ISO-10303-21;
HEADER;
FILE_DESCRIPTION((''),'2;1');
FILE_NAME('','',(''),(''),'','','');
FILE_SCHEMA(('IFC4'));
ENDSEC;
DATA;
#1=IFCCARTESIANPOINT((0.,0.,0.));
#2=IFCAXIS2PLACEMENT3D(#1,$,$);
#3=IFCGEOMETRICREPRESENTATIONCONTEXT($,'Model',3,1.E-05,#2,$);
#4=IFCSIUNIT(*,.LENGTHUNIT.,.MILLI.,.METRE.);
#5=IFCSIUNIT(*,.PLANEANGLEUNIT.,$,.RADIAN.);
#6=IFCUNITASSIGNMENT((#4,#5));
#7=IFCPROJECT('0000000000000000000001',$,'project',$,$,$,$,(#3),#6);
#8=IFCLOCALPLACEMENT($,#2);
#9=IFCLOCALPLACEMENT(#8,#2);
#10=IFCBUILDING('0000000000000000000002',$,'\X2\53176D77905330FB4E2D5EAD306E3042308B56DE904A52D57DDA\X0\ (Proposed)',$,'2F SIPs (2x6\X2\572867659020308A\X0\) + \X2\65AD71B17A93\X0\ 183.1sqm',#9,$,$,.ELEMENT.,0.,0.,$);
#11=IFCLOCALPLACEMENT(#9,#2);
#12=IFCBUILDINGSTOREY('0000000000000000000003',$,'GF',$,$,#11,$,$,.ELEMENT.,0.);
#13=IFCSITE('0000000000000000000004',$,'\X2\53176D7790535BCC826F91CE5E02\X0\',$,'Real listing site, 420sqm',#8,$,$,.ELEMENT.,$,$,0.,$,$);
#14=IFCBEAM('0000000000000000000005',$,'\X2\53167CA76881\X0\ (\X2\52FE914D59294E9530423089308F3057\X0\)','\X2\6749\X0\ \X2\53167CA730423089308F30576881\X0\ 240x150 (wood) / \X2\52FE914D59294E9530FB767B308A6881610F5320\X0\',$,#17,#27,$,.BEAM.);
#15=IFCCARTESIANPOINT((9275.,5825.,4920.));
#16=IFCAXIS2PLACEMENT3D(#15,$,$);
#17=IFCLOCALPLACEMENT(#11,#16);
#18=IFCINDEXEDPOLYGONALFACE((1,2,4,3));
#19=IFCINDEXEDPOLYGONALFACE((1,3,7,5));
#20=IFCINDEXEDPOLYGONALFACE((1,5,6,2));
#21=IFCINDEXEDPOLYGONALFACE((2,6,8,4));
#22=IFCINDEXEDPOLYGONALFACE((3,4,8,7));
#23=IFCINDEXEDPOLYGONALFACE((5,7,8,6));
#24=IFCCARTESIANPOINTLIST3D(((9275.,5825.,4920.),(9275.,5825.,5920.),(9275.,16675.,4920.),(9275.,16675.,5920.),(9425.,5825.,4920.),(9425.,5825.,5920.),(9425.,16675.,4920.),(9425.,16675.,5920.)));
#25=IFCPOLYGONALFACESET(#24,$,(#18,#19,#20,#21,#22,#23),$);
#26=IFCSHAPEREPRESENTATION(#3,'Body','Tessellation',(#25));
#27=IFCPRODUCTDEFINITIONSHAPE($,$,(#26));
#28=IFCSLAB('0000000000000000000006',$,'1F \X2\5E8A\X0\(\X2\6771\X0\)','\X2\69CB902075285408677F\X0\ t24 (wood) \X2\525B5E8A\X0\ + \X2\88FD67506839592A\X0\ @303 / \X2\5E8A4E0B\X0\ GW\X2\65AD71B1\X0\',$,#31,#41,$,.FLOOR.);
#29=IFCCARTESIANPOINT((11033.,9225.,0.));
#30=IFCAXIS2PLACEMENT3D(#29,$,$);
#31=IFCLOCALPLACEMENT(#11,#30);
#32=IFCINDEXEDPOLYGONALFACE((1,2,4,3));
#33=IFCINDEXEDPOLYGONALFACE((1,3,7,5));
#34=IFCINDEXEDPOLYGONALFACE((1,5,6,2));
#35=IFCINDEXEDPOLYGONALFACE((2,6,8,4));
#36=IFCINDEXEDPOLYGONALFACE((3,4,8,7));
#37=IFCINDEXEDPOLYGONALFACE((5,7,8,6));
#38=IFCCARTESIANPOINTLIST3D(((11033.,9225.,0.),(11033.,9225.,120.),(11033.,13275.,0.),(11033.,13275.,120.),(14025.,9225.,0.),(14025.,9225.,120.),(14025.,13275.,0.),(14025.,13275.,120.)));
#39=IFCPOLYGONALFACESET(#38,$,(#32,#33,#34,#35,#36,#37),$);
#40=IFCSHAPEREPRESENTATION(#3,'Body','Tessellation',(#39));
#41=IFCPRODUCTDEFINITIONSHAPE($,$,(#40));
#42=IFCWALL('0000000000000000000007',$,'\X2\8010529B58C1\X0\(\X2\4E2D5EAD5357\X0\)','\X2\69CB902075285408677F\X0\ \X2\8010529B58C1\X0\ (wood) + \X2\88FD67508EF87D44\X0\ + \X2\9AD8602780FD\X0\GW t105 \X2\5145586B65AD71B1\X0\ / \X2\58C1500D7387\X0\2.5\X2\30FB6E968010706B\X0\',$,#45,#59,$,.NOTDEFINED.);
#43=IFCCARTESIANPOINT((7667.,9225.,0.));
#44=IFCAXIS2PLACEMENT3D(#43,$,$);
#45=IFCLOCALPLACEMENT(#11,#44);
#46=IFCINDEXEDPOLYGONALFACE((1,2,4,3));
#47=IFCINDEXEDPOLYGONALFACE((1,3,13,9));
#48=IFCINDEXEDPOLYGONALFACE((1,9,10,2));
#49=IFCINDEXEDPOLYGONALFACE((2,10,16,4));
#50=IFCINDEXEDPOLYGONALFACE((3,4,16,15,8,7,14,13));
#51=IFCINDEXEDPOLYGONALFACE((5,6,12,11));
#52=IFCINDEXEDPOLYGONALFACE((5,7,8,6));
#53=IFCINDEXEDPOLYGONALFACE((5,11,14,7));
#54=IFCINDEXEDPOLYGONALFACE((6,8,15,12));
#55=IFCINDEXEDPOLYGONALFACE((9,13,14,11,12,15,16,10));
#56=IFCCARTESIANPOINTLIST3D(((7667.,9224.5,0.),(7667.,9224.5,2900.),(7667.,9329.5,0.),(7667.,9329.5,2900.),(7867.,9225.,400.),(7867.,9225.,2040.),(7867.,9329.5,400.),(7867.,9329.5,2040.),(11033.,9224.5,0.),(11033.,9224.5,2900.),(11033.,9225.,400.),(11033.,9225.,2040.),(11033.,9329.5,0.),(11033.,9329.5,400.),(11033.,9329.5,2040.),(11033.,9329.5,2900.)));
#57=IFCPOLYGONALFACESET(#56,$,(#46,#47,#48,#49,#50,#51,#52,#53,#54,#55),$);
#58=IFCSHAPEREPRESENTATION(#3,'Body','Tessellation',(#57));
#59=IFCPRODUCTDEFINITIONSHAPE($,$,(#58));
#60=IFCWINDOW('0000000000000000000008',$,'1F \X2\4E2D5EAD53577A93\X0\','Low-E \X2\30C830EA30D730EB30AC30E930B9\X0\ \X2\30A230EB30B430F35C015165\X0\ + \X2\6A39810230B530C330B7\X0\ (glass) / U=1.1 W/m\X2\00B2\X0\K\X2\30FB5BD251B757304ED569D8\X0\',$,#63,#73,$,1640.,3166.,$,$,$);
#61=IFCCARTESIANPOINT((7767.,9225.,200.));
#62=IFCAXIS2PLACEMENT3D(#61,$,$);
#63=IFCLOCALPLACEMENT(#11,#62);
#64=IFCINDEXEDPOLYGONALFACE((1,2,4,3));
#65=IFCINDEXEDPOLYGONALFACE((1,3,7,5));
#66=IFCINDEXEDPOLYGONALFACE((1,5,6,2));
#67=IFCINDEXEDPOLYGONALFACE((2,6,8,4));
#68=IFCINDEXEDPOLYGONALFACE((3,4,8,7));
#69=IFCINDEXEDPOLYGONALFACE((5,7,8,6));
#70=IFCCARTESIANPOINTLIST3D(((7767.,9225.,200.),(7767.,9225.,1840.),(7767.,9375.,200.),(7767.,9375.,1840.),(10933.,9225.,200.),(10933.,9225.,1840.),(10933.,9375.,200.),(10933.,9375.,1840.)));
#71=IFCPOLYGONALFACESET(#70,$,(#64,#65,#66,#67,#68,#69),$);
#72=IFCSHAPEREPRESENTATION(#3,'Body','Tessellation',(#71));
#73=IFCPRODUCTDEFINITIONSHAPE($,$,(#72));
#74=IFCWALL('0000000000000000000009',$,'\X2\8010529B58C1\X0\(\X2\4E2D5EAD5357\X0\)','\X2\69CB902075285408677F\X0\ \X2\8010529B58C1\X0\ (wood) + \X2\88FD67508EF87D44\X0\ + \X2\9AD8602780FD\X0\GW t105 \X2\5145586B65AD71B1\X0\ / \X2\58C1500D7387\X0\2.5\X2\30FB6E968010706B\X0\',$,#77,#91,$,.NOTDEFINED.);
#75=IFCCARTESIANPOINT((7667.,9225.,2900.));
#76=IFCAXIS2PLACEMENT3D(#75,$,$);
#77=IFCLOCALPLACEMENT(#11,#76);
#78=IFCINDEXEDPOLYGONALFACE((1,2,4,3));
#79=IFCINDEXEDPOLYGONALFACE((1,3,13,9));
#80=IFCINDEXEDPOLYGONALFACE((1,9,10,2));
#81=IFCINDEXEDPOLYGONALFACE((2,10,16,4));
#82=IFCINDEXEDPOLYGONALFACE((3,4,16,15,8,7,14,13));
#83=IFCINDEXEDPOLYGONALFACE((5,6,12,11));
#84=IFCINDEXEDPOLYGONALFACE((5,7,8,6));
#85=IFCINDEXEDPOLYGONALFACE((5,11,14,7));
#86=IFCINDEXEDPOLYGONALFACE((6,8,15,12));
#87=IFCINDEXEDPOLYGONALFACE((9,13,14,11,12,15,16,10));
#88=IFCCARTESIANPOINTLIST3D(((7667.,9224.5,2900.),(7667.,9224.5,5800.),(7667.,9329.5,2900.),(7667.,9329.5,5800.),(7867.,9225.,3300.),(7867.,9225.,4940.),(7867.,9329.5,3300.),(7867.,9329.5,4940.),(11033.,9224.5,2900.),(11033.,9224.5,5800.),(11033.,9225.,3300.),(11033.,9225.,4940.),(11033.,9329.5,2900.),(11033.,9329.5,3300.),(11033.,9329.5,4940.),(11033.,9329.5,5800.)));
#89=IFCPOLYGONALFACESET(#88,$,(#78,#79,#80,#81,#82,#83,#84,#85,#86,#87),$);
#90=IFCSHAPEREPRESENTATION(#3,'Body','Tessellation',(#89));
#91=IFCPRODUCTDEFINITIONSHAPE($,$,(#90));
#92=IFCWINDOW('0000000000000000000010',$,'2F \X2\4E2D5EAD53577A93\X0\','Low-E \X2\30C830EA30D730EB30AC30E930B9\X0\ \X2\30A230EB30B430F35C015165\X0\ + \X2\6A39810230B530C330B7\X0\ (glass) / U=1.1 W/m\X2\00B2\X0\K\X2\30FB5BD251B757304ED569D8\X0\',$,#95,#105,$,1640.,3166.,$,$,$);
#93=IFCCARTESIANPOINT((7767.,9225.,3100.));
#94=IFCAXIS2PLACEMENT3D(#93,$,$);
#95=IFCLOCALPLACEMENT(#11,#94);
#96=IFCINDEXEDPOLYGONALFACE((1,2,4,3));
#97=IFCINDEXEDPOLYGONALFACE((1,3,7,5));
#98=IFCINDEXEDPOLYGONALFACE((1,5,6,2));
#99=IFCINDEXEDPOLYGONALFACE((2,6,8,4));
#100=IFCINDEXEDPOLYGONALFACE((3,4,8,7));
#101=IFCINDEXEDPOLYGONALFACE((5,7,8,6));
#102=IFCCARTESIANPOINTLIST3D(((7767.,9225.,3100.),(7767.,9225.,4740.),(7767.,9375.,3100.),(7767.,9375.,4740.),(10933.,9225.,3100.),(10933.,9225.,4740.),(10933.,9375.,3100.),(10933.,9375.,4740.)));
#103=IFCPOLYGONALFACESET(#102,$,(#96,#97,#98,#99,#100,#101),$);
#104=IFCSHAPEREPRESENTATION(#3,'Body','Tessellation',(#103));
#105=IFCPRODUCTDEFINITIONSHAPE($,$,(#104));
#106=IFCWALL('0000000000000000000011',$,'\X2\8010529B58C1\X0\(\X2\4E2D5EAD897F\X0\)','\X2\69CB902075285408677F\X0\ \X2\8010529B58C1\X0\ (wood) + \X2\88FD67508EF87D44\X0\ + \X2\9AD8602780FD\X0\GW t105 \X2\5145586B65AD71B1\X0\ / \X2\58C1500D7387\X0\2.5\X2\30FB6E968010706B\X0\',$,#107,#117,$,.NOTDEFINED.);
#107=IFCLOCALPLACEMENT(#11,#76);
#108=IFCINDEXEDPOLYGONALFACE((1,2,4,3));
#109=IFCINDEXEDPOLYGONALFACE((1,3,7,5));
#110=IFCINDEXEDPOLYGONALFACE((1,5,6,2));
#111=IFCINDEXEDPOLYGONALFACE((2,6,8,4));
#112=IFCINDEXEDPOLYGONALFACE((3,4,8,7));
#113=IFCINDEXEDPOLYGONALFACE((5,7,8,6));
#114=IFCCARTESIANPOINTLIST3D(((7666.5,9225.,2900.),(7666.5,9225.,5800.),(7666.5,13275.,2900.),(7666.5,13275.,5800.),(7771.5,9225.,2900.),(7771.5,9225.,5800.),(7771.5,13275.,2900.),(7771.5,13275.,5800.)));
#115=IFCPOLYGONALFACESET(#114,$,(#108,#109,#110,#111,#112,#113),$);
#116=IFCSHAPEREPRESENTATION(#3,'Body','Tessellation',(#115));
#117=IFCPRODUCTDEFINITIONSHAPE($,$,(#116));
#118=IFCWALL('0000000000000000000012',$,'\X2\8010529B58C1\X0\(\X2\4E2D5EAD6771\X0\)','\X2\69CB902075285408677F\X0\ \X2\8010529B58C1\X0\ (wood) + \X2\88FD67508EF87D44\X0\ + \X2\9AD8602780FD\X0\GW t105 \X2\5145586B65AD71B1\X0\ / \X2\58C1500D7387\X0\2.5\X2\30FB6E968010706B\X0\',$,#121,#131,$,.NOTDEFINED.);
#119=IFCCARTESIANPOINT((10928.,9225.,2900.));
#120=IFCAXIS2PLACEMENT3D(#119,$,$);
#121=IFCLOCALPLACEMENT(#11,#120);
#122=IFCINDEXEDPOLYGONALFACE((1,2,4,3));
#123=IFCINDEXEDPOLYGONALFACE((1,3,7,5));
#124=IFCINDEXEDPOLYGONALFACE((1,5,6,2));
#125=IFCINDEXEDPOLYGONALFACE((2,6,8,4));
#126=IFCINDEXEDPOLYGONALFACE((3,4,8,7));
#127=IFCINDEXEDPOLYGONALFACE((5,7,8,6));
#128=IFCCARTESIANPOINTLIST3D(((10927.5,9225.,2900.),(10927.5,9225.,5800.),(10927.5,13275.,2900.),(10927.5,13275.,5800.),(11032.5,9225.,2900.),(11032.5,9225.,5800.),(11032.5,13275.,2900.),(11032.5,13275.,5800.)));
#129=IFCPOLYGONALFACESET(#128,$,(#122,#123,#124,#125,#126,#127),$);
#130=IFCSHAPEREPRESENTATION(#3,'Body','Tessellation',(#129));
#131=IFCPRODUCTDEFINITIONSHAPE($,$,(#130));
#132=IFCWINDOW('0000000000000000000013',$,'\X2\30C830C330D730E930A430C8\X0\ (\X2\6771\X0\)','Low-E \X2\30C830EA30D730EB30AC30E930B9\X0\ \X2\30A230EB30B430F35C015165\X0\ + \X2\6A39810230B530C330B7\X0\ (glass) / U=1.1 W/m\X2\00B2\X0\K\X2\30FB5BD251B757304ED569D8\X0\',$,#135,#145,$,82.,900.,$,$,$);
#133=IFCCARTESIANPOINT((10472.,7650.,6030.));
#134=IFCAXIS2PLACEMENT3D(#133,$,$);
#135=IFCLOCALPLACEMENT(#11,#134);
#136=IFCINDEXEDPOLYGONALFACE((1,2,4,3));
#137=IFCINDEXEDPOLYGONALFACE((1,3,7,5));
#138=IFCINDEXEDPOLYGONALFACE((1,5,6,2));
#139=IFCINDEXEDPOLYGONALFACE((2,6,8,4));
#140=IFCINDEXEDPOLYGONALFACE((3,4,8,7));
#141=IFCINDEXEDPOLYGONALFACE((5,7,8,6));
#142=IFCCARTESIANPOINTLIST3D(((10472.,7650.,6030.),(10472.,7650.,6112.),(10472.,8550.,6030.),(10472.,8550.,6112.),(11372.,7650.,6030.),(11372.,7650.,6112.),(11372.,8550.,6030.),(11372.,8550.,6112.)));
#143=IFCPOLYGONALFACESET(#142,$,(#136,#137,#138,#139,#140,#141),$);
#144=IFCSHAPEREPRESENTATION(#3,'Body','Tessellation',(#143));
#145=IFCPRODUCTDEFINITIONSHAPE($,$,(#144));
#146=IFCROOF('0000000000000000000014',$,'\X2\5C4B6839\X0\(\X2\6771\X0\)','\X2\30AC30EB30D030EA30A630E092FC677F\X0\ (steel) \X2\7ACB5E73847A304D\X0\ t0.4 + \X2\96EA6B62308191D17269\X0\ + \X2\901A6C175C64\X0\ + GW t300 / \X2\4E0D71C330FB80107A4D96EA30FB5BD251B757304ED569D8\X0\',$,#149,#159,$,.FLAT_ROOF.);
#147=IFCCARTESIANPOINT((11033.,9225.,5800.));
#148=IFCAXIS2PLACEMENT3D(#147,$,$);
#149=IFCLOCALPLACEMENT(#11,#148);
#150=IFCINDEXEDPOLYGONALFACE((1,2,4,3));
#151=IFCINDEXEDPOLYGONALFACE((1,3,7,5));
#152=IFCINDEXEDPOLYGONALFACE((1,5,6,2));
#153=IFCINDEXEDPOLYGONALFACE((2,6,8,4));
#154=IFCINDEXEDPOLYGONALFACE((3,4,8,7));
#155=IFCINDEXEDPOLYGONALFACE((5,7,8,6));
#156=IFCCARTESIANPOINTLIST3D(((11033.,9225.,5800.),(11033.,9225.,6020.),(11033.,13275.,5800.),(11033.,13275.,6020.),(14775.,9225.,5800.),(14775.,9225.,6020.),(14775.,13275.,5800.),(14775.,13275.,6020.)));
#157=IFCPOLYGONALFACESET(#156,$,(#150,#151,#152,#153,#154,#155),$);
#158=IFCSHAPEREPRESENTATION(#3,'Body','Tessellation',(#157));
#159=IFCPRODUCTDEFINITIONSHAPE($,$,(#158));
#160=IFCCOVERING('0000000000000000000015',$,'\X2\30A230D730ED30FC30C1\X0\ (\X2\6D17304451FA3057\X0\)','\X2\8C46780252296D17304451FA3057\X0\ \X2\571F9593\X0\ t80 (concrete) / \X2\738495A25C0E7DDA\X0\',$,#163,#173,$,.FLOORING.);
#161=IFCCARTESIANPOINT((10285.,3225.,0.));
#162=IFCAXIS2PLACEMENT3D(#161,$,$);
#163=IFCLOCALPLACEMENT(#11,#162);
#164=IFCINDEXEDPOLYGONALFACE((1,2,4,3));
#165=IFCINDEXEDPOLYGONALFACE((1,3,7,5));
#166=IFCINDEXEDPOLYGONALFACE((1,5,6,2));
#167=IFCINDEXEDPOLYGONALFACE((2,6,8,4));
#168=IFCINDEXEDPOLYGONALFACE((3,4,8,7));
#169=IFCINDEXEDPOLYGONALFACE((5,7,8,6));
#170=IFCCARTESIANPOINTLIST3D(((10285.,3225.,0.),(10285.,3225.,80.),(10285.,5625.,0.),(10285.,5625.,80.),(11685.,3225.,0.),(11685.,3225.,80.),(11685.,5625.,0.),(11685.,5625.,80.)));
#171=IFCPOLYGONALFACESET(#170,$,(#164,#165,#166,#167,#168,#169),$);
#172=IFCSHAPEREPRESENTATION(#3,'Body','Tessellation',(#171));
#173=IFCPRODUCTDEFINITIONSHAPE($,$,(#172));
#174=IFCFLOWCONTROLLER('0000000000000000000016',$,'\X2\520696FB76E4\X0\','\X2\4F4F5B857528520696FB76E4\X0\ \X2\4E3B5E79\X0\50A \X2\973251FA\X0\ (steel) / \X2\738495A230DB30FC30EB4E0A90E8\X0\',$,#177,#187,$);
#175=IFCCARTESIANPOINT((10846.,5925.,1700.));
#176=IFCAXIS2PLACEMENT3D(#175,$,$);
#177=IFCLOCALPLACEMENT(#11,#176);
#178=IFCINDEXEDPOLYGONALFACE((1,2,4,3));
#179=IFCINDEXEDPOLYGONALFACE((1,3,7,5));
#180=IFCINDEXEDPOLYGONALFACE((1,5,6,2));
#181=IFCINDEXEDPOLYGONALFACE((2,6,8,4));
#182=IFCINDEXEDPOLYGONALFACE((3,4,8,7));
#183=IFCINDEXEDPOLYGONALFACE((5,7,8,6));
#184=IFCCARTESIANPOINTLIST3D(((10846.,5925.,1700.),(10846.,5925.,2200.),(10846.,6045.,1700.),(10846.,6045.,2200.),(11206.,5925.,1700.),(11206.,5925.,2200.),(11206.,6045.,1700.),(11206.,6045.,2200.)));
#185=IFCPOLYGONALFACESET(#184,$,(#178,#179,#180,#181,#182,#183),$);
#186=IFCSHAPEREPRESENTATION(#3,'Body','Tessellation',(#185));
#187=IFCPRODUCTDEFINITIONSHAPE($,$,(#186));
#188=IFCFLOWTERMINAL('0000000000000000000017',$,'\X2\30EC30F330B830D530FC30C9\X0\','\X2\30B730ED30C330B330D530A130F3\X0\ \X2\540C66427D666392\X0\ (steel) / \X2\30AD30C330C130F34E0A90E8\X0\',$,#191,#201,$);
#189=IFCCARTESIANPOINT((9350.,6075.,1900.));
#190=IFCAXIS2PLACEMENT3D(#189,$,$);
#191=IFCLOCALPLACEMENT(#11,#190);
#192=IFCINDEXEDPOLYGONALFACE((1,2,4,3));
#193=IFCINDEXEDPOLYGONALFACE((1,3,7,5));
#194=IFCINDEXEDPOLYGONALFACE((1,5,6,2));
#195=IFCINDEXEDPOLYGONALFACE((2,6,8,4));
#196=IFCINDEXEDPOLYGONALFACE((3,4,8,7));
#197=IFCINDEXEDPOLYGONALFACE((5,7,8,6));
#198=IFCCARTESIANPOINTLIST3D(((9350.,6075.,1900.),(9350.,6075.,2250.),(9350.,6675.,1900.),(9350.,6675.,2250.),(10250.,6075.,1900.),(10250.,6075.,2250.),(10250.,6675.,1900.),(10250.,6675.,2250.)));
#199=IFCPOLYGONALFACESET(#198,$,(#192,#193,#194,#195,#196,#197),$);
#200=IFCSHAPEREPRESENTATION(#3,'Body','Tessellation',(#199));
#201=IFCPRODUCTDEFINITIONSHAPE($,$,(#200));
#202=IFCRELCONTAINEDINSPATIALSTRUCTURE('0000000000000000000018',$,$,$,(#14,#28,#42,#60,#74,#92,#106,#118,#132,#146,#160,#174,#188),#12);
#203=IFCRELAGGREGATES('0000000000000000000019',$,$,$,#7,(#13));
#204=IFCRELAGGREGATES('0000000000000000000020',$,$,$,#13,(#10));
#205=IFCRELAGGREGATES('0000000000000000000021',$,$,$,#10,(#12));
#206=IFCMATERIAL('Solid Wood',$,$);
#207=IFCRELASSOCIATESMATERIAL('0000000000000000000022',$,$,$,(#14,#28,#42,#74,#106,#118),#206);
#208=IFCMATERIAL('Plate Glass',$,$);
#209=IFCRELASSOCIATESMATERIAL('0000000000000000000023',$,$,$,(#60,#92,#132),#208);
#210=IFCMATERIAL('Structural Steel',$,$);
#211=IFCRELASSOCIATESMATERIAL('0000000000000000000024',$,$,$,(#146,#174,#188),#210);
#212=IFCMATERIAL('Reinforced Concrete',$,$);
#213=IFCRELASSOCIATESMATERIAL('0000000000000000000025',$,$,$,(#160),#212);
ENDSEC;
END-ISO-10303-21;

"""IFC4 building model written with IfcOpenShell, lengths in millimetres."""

from ifc_helpers import new_model, si_unit, frame, frame_2d, origin, place, context, project, spatial, rectangle, extrude, material, element, fill, save


model = new_model("IFC4")

# Units and contexts
model_context = context("Model", 3, precision=1e-05, world=origin())
ifc_project = project(units=[si_unit("LENGTHUNIT", "METRE", prefix="MILLI"), si_unit("PLANEANGLEUNIT", "RADIAN")], contexts=[model_context])

# Site, building, storey
site_placement = place(None, origin())
site = spatial("IfcSite", under=ifc_project, at=site_placement, Name="北海道富良野市", ObjectType="Real listing site, 420sqm", CompositionType="ELEMENT", RefElevation=0.0)
building_placement = place(site_placement, origin())
building = spatial("IfcBuilding", under=site, at=building_placement, Name="北海道・中庭のある回遊動線 (Proposed)", ObjectType="2F SIPs (2x6在来造り) + 断熱窓 183.1sqm", CompositionType="ELEMENT", ElevationOfRefHeight=0.0, ElevationOfTerrain=0.0)
storey_placement = place(building_placement, origin())
storey = spatial("IfcBuildingStorey", under=building, at=storey_placement, Name="GF", CompositionType="ELEMENT", Elevation=0.0)

# Shared definitions
ifc_material_1 = material(Name="Solid Wood")

# Beam
beam_placement = place(storey_placement, frame((9275.0, 5825.0, 4920.0)))
element("IfcBeam", 1, at=beam_placement, inside=storey, material=ifc_material_1, Name="化粧梁 (勾配天井あらわし)", Description="杉 化粧あらわし梁 240x150 (wood) / 勾配天井・登り梁意匠", PredefinedType="BEAM", context=model_context, shape_type="SweptSolid", body=[
    extrude(rectangle(XDim=150.0, YDim=10850.0, at=frame_2d((75.0, 5425.0))), frame((9275.0, 5825.0, 4920.0)), (0.0, 0.0, 1.0), 1000.0),
])

# Slab
slab_placement = place(storey_placement, frame((11033.0, 9225.0, 0.0)))
element("IfcSlab", 2, at=slab_placement, inside=storey, material=ifc_material_1, Name="1F 床(東)", Description="構造用合板 t24 (wood) 剛床 + 製材根太 @303 / 床下 GW断熱", PredefinedType="FLOOR", context=model_context, shape_type="SweptSolid", body=[
    extrude(rectangle(XDim=2992.0, YDim=4050.0, at=frame_2d((1496.0, 2025.0))), frame((11033.0, 9225.0, 0.0)), (0.0, 0.0, 1.0), 120.0),
])

# Wall, opening, window
wall_1_placement = place(storey_placement, frame((7667.0, 9225.0, 0.0)))
wall_1 = element("IfcWall", 3, at=wall_1_placement, inside=storey, material=ifc_material_1, Name="耐力壁(中庭南)", Description="構造用合板 耐力壁 (wood) + 製材軸組 + 高性能GW t105 充填断熱 / 壁倍率2.5・準耐火", PredefinedType="NOTDEFINED", context=model_context, shape_type="SweptSolid", body=[
    extrude(rectangle(XDim=3366.0, YDim=105.0, at=frame_2d((1683.0, 52.0))), frame((7667.0, 9225.0, 0.0)), (0.0, 0.0, 1.0), 2900.0),
])
opening_1_placement = place(storey_placement, frame((7767.0, 9225.0, 200.0)))
opening_1 = element("IfcOpeningElement", 4, at=opening_1_placement, cuts=wall_1, PredefinedType="NOTDEFINED", context=model_context, shape_type="SweptSolid", body=[
    extrude(rectangle(XDim=3166.0, YDim=150.0, at=frame_2d((1583.0, 75.0))), frame((7767.0, 9225.0, 200.0)), (0.0, 0.0, 1.0), 1640.0),
])
ifc_material_2 = material(Name="Plate Glass")
window_1_placement = place(storey_placement, frame((7767.0, 9225.0, 200.0)))
window_1 = element("IfcWindow", 5, at=window_1_placement, inside=storey, material=ifc_material_2, Name="1F 中庭南窓", Description="Low-E トリプルガラス アルゴン封入 + 樹脂サッシ (glass) / U=1.1 W/m²K・寒冷地仕様", OverallHeight=1640.0, OverallWidth=3166.0, context=model_context, shape_type="SweptSolid", body=[
    extrude(rectangle(XDim=3166.0, YDim=150.0, at=frame_2d((1583.0, 75.0))), frame((7767.0, 9225.0, 200.0)), (0.0, 0.0, 1.0), 1640.0),
])
fill(opening_1, window_1)

# Wall, opening, window
wall_2_placement = place(storey_placement, frame((7667.0, 9225.0, 2900.0)))
wall_2 = element("IfcWall", 6, at=wall_2_placement, inside=storey, material=ifc_material_1, Name="耐力壁(中庭南)", Description="構造用合板 耐力壁 (wood) + 製材軸組 + 高性能GW t105 充填断熱 / 壁倍率2.5・準耐火", PredefinedType="NOTDEFINED", context=model_context, shape_type="SweptSolid", body=[
    extrude(rectangle(XDim=3366.0, YDim=105.0, at=frame_2d((1683.0, 52.0))), frame((7667.0, 9225.0, 2900.0)), (0.0, 0.0, 1.0), 2900.0),
])
opening_2_placement = place(storey_placement, frame((7767.0, 9225.0, 3100.0)))
opening_2 = element("IfcOpeningElement", 7, at=opening_2_placement, cuts=wall_2, PredefinedType="NOTDEFINED", context=model_context, shape_type="SweptSolid", body=[
    extrude(rectangle(XDim=3166.0, YDim=150.0, at=frame_2d((1583.0, 75.0))), frame((7767.0, 9225.0, 3100.0)), (0.0, 0.0, 1.0), 1640.0),
])
window_2_placement = place(storey_placement, frame((7767.0, 9225.0, 3100.0)))
window_2 = element("IfcWindow", 8, at=window_2_placement, inside=storey, material=ifc_material_2, Name="2F 中庭南窓", Description="Low-E トリプルガラス アルゴン封入 + 樹脂サッシ (glass) / U=1.1 W/m²K・寒冷地仕様", OverallHeight=1640.0, OverallWidth=3166.0, context=model_context, shape_type="SweptSolid", body=[
    extrude(rectangle(XDim=3166.0, YDim=150.0, at=frame_2d((1583.0, 75.0))), frame((7767.0, 9225.0, 3100.0)), (0.0, 0.0, 1.0), 1640.0),
])
fill(opening_2, window_2)

# Walls
wall_3_placement = place(storey_placement, frame((7667.0, 9225.0, 2900.0)))
element("IfcWall", 9, at=wall_3_placement, inside=storey, material=ifc_material_1, Name="耐力壁(中庭西)", Description="構造用合板 耐力壁 (wood) + 製材軸組 + 高性能GW t105 充填断熱 / 壁倍率2.5・準耐火", PredefinedType="NOTDEFINED", context=model_context, shape_type="SweptSolid", body=[
    extrude(rectangle(XDim=105.0, YDim=4050.0, at=frame_2d((52.0, 2025.0))), frame((7667.0, 9225.0, 2900.0)), (0.0, 0.0, 1.0), 2900.0),
])
wall_4_placement = place(storey_placement, frame((10928.0, 9225.0, 2900.0)))
element("IfcWall", 10, at=wall_4_placement, inside=storey, material=ifc_material_1, Name="耐力壁(中庭東)", Description="構造用合板 耐力壁 (wood) + 製材軸組 + 高性能GW t105 充填断熱 / 壁倍率2.5・準耐火", PredefinedType="NOTDEFINED", context=model_context, shape_type="SweptSolid", body=[
    extrude(rectangle(XDim=105.0, YDim=4050.0, at=frame_2d((52.0, 2025.0))), frame((10928.0, 9225.0, 2900.0)), (0.0, 0.0, 1.0), 2900.0),
])

# Window
window_3_placement = place(storey_placement, frame((10472.0, 7650.0, 6030.0)))
element("IfcWindow", 11, at=window_3_placement, inside=storey, material=ifc_material_2, Name="トップライト (東)", Description="Low-E トリプルガラス アルゴン封入 + 樹脂サッシ (glass) / U=1.1 W/m²K・寒冷地仕様", OverallHeight=82.0, OverallWidth=900.0, context=model_context, shape_type="SweptSolid", body=[
    extrude(rectangle(XDim=900.0, YDim=900.0, at=frame_2d((450.0, 450.0))), frame((10472.0, 7650.0, 6030.0)), (0.0, 0.0, 1.0), 82.0),
])

# Roof
ifc_material_3 = material(Name="Structural Steel")
roof_placement = place(storey_placement, frame((11033.0, 9225.0, 5800.0)))
element("IfcRoof", 12, at=roof_placement, inside=storey, material=ifc_material_3, Name="屋根(東)", Description="ガルバリウム鋼板 (steel) 立平葺き t0.4 + 雪止め金物 + 通気層 + GW t300 / 不燃・耐積雪・寒冷地仕様", PredefinedType="FLAT_ROOF", context=model_context, shape_type="SweptSolid", body=[
    extrude(rectangle(XDim=3742.0, YDim=4050.0, at=frame_2d((1871.0, 2025.0))), frame((11033.0, 9225.0, 5800.0)), (0.0, 0.0, 1.0), 220.0),
])

# Covering
ifc_material_4 = material(Name="Reinforced Concrete")
covering_placement = place(storey_placement, frame((10285.0, 3225.0, 0.0)))
element("IfcCovering", 13, at=covering_placement, inside=storey, material=ifc_material_4, Name="アプローチ (洗い出し)", Description="豆砂利洗い出し 土間 t80 (concrete) / 玄関導線", PredefinedType="FLOORING", context=model_context, shape_type="SweptSolid", body=[
    extrude(rectangle(XDim=1400.0, YDim=2400.0, at=frame_2d((700.0, 1200.0))), frame((10285.0, 3225.0, 0.0)), (0.0, 0.0, 1.0), 80.0),
])

# Flow controller
flow_controller_placement = place(storey_placement, frame((10846.0, 5925.0, 1700.0)))
element("IfcFlowController", 14, at=flow_controller_placement, inside=storey, material=ifc_material_3, Name="分電盤", Description="住宅用分電盤 主幹50A 露出 (steel) / 玄関ホール上部", context=model_context, shape_type="SweptSolid", body=[
    extrude(rectangle(XDim=360.0, YDim=120.0, at=frame_2d((180.0, 60.0))), frame((10846.0, 5925.0, 1700.0)), (0.0, 0.0, 1.0), 500.0),
])

# Flow terminal
flow_terminal_1_placement = place(storey_placement, frame((9350.0, 6075.0, 1900.0)))
element("IfcFlowTerminal", 15, at=flow_terminal_1_placement, inside=storey, material=ifc_material_3, Name="レンジフード", Description="シロッコファン 同時給排 (steel) / キッチン上部", context=model_context, shape_type="SweptSolid", body=[
    extrude(rectangle(XDim=900.0, YDim=600.0, at=frame_2d((450.0, 300.0))), frame((9350.0, 6075.0, 1900.0)), (0.0, 0.0, 1.0), 350.0),
])

save(model, "model.ifc")
